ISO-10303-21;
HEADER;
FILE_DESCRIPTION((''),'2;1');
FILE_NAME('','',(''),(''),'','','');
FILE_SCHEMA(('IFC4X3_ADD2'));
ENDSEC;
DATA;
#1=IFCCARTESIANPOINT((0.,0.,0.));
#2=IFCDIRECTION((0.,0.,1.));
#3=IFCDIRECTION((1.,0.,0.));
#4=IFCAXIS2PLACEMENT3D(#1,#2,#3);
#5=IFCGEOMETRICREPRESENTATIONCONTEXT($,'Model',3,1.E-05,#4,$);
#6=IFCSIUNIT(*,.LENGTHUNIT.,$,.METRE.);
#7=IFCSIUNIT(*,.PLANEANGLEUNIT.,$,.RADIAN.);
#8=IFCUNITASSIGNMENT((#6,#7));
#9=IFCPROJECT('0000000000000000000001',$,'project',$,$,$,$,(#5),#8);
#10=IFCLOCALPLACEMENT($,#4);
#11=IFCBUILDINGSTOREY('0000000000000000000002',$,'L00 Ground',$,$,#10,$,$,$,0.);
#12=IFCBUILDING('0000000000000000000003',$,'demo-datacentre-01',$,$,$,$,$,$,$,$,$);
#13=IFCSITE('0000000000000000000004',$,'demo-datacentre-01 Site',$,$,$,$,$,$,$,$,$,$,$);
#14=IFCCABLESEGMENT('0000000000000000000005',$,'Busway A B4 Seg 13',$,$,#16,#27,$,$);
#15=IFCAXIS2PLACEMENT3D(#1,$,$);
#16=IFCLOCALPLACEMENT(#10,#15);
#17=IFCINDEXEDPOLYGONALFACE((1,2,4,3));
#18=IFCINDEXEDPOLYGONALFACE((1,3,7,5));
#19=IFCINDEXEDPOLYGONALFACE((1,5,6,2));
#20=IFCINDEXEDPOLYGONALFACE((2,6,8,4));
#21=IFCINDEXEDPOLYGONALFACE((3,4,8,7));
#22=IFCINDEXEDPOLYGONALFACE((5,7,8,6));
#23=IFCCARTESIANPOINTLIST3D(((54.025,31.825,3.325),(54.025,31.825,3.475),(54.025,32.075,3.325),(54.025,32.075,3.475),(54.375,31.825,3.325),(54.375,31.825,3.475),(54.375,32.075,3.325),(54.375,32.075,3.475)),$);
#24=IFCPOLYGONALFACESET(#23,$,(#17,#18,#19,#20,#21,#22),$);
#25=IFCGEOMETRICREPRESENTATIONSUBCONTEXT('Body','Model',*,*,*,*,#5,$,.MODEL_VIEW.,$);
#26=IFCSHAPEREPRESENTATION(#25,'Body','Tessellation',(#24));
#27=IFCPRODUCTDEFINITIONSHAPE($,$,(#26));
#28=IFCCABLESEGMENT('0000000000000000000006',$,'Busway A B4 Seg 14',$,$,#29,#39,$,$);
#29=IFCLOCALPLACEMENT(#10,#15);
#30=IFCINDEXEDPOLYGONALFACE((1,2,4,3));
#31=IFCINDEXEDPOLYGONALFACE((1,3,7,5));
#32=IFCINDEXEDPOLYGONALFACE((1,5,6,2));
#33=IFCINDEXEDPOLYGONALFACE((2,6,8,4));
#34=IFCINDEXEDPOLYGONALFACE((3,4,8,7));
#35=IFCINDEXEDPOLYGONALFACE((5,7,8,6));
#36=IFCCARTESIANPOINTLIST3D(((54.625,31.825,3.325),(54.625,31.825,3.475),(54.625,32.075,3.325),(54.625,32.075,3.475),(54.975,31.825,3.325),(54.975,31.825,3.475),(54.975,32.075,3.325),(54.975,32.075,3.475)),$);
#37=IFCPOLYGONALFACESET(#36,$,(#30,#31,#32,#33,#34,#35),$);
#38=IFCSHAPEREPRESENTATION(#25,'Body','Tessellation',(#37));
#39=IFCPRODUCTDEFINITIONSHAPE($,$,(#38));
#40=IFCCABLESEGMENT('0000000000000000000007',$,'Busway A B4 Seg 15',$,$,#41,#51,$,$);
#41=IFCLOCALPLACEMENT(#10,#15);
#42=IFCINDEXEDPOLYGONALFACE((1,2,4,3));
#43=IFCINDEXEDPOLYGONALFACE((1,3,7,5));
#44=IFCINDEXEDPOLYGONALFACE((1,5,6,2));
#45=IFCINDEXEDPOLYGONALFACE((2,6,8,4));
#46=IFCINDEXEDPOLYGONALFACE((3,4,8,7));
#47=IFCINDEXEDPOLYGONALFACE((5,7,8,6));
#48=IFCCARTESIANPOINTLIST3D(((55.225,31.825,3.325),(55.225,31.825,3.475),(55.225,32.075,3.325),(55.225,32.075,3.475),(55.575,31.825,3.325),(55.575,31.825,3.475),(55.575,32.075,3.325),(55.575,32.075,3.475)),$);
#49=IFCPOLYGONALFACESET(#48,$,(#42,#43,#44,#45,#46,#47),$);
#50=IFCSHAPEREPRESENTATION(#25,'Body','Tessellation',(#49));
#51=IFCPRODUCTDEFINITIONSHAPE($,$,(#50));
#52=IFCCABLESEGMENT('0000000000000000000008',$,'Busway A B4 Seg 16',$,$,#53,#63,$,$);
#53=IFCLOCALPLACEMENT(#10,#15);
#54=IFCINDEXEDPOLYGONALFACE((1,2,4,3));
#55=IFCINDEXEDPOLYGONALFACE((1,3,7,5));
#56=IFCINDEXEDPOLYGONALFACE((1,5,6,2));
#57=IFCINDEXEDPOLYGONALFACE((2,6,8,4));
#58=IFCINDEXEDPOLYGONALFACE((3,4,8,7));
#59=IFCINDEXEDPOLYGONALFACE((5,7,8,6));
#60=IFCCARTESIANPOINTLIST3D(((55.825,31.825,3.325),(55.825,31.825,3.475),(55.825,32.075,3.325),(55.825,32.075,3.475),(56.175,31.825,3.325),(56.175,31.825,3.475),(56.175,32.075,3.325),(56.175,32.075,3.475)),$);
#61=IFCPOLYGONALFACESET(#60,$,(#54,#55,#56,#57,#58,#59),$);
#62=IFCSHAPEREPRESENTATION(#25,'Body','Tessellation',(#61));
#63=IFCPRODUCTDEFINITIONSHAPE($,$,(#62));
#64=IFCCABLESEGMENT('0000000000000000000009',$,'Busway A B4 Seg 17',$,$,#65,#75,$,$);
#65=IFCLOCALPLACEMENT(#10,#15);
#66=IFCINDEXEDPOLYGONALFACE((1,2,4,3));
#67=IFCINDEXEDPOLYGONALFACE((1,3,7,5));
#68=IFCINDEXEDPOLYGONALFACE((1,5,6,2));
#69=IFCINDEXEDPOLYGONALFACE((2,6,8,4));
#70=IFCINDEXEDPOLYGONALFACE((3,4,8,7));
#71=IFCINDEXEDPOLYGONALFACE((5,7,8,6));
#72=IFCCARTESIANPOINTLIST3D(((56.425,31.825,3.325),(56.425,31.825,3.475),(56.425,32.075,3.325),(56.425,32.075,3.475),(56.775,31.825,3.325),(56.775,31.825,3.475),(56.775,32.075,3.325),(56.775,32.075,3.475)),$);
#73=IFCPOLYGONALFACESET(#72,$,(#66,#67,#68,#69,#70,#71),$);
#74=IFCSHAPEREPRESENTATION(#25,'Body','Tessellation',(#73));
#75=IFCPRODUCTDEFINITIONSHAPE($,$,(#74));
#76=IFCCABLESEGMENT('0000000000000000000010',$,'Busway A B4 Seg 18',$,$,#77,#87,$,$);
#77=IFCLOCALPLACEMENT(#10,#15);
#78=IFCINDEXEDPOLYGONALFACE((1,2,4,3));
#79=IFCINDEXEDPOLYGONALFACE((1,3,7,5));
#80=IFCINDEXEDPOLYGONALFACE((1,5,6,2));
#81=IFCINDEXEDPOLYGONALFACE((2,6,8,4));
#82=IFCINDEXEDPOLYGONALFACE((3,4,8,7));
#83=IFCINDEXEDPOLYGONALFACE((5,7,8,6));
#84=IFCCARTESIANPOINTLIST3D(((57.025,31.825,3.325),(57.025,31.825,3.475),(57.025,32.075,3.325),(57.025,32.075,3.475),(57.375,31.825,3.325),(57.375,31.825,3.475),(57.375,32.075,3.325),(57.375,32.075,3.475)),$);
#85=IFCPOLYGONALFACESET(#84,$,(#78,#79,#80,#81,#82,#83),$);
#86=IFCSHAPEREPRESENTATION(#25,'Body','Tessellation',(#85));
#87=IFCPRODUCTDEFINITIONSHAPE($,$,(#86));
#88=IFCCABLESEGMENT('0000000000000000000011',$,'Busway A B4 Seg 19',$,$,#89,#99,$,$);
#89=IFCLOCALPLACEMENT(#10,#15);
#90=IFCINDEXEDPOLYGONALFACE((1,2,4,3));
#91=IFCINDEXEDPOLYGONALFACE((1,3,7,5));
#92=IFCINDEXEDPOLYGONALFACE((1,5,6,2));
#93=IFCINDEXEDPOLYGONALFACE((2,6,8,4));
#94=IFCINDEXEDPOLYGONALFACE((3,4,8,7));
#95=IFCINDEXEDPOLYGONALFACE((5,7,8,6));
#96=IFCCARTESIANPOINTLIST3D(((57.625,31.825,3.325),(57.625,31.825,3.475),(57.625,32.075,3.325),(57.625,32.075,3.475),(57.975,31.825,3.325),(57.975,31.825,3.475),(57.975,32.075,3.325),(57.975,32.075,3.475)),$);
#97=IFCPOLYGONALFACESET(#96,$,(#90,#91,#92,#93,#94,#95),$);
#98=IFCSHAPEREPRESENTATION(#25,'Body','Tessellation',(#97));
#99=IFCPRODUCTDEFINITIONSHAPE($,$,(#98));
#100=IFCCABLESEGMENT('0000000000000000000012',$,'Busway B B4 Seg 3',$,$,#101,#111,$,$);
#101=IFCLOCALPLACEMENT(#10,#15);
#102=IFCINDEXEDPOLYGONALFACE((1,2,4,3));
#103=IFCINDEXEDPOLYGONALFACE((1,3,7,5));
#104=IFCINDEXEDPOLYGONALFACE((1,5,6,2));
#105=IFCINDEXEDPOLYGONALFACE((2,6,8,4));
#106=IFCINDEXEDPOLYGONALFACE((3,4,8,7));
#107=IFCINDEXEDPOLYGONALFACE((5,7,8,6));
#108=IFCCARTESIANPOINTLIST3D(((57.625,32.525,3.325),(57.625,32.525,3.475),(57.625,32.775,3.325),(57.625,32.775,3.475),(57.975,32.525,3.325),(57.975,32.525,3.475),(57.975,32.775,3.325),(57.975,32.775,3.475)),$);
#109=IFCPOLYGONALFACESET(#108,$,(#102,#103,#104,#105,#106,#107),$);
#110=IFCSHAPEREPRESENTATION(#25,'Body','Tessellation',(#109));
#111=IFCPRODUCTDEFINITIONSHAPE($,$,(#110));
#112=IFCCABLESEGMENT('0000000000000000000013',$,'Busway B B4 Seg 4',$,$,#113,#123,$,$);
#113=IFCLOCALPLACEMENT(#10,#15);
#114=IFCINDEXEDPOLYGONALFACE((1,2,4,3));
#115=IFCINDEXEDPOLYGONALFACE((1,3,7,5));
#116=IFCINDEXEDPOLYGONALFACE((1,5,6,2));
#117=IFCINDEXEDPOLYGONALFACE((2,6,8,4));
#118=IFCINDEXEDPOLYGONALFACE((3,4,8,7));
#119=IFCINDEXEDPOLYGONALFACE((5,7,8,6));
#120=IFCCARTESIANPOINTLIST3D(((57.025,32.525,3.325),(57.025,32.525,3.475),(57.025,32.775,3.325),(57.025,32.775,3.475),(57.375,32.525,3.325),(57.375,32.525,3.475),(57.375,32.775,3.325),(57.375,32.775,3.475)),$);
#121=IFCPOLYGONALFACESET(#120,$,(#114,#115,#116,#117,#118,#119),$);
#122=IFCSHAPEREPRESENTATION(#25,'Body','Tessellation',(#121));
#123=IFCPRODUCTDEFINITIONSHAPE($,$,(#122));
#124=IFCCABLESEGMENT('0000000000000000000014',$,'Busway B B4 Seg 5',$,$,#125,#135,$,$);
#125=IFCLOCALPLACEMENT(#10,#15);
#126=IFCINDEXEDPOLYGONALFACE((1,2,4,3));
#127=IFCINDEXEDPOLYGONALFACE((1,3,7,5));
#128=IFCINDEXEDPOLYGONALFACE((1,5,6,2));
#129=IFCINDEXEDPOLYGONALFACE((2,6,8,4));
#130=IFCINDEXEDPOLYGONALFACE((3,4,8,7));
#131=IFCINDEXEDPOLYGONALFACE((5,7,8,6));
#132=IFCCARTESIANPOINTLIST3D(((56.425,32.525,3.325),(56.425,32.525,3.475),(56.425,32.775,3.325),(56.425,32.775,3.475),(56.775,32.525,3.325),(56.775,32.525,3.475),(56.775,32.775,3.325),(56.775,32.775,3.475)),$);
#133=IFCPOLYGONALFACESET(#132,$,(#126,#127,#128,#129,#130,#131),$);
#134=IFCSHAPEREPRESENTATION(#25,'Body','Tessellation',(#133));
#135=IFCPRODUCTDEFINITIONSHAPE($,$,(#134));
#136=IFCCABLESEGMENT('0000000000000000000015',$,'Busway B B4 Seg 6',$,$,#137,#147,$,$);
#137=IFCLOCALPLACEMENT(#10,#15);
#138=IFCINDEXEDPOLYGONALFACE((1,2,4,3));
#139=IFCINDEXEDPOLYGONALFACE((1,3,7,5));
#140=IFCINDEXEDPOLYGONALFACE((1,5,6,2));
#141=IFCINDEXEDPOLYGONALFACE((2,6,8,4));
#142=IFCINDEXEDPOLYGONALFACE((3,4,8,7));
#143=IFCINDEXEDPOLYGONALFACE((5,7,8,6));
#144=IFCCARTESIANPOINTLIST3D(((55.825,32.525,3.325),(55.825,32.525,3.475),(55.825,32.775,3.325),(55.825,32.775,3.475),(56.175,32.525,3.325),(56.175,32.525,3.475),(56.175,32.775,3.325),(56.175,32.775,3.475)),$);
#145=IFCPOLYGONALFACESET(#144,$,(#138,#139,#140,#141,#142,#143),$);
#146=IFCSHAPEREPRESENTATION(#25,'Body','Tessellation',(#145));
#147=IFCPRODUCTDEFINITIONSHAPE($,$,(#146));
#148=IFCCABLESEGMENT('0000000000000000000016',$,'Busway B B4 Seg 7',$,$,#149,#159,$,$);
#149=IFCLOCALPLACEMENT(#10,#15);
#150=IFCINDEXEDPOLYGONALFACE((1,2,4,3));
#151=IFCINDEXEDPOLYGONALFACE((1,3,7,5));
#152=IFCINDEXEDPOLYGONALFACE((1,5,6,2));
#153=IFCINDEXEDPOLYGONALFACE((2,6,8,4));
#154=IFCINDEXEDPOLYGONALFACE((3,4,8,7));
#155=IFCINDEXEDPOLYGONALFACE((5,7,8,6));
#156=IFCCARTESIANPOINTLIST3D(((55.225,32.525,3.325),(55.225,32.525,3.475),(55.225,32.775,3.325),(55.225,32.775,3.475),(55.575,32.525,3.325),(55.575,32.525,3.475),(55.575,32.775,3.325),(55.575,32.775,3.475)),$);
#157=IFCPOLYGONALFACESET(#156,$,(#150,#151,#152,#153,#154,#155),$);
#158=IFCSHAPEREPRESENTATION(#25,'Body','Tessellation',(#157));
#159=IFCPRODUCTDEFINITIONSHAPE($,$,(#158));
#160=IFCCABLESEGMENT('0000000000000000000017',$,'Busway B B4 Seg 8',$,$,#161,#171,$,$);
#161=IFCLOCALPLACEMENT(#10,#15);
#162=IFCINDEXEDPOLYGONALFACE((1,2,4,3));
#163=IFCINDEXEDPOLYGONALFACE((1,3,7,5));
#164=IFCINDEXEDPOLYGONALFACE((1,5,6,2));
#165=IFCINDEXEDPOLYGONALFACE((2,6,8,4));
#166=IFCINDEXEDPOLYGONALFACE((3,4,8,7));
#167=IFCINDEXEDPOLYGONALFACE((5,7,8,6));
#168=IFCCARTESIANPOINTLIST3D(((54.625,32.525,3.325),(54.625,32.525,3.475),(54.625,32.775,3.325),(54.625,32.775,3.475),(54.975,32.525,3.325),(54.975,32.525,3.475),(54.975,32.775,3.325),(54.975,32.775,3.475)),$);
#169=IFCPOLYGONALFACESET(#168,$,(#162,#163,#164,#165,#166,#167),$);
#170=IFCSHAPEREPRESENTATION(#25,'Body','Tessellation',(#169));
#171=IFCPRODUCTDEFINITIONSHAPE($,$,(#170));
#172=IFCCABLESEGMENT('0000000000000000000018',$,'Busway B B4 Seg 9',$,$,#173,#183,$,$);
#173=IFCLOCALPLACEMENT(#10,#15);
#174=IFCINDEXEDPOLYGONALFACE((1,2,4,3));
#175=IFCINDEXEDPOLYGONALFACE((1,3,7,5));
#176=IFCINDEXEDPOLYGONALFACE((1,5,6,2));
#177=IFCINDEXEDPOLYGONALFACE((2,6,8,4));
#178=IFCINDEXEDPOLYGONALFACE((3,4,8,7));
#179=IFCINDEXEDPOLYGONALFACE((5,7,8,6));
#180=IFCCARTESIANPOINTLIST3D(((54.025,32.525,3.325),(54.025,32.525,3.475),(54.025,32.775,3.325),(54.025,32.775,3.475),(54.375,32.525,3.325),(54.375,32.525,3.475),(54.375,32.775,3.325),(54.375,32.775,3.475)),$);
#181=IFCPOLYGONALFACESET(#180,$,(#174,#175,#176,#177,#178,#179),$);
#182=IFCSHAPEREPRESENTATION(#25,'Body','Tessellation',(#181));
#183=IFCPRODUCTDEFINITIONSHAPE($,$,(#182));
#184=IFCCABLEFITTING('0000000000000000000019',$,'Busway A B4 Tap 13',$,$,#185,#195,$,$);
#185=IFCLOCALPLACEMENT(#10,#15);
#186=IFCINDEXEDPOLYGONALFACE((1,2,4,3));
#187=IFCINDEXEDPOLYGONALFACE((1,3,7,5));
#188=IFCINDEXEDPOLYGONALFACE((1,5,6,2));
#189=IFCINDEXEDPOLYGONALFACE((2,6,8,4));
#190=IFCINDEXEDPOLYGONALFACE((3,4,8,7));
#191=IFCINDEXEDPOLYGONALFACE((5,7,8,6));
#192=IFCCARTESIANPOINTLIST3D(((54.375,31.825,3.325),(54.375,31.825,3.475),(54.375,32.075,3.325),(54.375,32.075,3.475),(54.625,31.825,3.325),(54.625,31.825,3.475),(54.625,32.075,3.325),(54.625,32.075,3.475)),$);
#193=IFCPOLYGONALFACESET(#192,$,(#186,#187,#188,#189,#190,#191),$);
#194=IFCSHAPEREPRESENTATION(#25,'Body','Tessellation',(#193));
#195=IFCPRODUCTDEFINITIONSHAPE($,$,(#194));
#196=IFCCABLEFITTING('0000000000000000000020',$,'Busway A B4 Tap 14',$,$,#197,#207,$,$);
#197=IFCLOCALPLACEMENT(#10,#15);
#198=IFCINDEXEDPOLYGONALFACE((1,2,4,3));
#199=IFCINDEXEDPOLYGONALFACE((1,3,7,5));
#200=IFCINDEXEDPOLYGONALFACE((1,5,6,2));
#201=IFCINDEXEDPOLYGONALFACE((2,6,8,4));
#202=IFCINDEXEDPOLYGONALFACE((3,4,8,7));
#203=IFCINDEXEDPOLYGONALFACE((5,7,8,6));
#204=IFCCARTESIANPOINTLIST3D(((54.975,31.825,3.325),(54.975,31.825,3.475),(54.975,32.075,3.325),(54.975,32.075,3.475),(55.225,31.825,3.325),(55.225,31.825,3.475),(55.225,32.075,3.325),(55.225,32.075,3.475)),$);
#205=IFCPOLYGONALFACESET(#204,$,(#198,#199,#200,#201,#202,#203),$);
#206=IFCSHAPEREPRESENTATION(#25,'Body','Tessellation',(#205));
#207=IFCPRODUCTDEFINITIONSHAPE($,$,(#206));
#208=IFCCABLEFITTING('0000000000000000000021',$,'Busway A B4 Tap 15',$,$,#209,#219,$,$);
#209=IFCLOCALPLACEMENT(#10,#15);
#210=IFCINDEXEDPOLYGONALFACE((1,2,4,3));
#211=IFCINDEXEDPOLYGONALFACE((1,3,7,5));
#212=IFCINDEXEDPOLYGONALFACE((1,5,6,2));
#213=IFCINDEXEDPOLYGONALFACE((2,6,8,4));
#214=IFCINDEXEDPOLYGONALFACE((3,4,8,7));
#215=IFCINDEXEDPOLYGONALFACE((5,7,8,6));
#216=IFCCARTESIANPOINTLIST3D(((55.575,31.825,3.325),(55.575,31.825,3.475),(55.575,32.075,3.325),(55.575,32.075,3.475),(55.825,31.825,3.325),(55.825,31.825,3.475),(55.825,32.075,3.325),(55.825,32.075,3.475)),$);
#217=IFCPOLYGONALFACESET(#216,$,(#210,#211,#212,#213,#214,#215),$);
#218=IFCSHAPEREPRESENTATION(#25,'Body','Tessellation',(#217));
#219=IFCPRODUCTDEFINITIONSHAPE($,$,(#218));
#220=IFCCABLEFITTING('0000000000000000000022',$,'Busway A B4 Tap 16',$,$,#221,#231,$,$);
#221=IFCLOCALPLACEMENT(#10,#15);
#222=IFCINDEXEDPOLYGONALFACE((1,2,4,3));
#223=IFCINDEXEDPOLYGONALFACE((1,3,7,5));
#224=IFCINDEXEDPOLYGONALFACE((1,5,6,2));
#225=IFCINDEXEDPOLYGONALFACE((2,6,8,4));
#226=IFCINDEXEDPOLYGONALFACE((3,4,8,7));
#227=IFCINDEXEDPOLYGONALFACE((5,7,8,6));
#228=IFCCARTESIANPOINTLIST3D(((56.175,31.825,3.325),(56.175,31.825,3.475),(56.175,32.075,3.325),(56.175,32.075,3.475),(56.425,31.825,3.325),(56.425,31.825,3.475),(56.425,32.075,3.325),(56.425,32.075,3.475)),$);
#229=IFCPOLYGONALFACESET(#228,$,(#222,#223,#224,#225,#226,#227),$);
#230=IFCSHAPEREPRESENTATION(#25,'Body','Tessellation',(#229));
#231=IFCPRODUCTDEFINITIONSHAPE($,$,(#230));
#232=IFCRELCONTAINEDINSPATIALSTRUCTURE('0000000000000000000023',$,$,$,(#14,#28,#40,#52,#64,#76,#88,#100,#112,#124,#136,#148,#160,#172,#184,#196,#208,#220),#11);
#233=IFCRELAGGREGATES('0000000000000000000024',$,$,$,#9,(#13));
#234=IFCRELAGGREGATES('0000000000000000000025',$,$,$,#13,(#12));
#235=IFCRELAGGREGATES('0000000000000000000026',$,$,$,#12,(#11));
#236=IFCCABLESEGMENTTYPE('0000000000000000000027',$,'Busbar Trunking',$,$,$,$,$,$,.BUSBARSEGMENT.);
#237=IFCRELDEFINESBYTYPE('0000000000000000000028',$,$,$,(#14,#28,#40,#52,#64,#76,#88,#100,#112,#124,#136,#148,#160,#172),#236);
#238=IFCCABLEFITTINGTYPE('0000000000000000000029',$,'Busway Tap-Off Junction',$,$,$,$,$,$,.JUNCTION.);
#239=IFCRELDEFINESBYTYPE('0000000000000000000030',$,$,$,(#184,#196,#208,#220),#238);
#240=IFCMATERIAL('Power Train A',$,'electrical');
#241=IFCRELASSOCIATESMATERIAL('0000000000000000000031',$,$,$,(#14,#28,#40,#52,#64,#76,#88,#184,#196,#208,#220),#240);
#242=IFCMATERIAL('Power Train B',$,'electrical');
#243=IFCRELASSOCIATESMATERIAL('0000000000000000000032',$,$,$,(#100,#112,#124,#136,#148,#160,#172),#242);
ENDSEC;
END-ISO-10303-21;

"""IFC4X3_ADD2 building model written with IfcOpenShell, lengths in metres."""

from ifc_helpers import new_model, si_unit, frame, origin_with_axes, place, context, subcontext, project, spatial, rectangle, extrude, material, type_object, element, save


model = new_model("IFC4X3_ADD2")

# Units and contexts
model_context = context("Model", 3, precision=1e-05, world=origin_with_axes())
body_context = subcontext(model_context, "Body", "Model", "MODEL_VIEW")
ifc_project = project(units=[si_unit("LENGTHUNIT", "METRE"), si_unit("PLANEANGLEUNIT", "RADIAN")], contexts=[model_context])

# Site, building, storey
site = spatial("IfcSite", under=ifc_project, Name="demo-datacentre-01 Site")
building = spatial("IfcBuilding", under=site, Name="demo-datacentre-01")
storey_placement = place(None, origin_with_axes())
storey = spatial("IfcBuildingStorey", under=building, at=storey_placement, Name="L00 Ground", Elevation=0.0)

# Cable segments
ifc_material_1 = material(Name="Power Train A", Category="electrical")
cable_segment_type_1 = type_object("IfcCableSegmentType", Name="Busbar Trunking", PredefinedType="BUSBARSEGMENT")
cable_segment_1_placement = place(storey_placement, frame((54.025, 31.95, 3.4), z_axis=(1.0, 0.0, 0.0), x_axis=(0.0, 1.0, 0.0)))
element("IfcCableSegment", 1, at=cable_segment_1_placement, inside=storey, type_object=cable_segment_type_1, material=ifc_material_1, Name="Busway A B4 Seg 13", context=body_context, shape_type="SweptSolid", body=[
    extrude(rectangle(XDim=0.25, YDim=0.15), origin_with_axes(), (0.0, 0.0, 1.0), 0.35),
])
cable_segment_2_placement = place(storey_placement, frame((54.625, 31.95, 3.4), z_axis=(1.0, 0.0, 0.0), x_axis=(0.0, 1.0, 0.0)))
element("IfcCableSegment", 2, at=cable_segment_2_placement, inside=storey, type_object=cable_segment_type_1, material=ifc_material_1, Name="Busway A B4 Seg 14", context=body_context, shape_type="SweptSolid", body=[
    extrude(rectangle(XDim=0.25, YDim=0.15), origin_with_axes(), (0.0, 0.0, 1.0), 0.35),
])
for number, where, z_axis, x_axis, name in (
    (3, (55.225, 31.95, 3.4), (1.0, 0.0, 0.0), (0.0, 1.0, 0.0), "Busway A B4 Seg 15"),
    (4, (55.825, 31.95, 3.4), (1.0, 0.0, 0.0), (0.0, 1.0, 0.0), "Busway A B4 Seg 16"),
    (5, (56.425, 31.95, 3.4), (1.0, 0.0, 0.0), (0.0, 1.0, 0.0), "Busway A B4 Seg 17"),
    (6, (57.025, 31.95, 3.4), (1.0, 0.0, 0.0), (0.0, 1.0, 0.0), "Busway A B4 Seg 18"),
):
    element("IfcCableSegment", number, at=place(storey_placement, frame(where, z_axis=z_axis, x_axis=x_axis)), inside=storey, type_object=cable_segment_type_1, material=ifc_material_1, Name=name, context=body_context, shape_type="SweptSolid", body=[
        extrude(rectangle(XDim=0.25, YDim=0.15), origin_with_axes(), (0.0, 0.0, 1.0), 0.35),
    ])
cable_segment_3_placement = place(storey_placement, frame((57.625, 31.95, 3.4), z_axis=(1.0, 0.0, 0.0), x_axis=(0.0, 1.0, 0.0)))
element("IfcCableSegment", 7, at=cable_segment_3_placement, inside=storey, type_object=cable_segment_type_1, material=ifc_material_1, Name="Busway A B4 Seg 19", context=body_context, shape_type="SweptSolid", body=[
    extrude(rectangle(XDim=0.25, YDim=0.15), origin_with_axes(), (0.0, 0.0, 1.0), 0.35),
])
ifc_material_2 = material(Name="Power Train B", Category="electrical")
cable_segment_4_placement = place(storey_placement, frame((57.975, 32.65, 3.4), z_axis=(-1.0, 0.0, 0.0), x_axis=(0.0, -1.0, 0.0)))
element("IfcCableSegment", 8, at=cable_segment_4_placement, inside=storey, type_object=cable_segment_type_1, material=ifc_material_2, Name="Busway B B4 Seg 3", context=body_context, shape_type="SweptSolid", body=[
    extrude(rectangle(XDim=0.25, YDim=0.15), origin_with_axes(), (0.0, 0.0, 1.0), 0.35),
])
for number, where, z_axis, x_axis, name in (
    (9, (57.375, 32.65, 3.4), (-1.0, 0.0, 0.0), (0.0, -1.0, 0.0), "Busway B B4 Seg 4"),
    (10, (56.775, 32.65, 3.4), (-1.0, 0.0, 0.0), (0.0, -1.0, 0.0), "Busway B B4 Seg 5"),
    (11, (56.175, 32.65, 3.4), (-1.0, 0.0, 0.0), (0.0, -1.0, 0.0), "Busway B B4 Seg 6"),
    (12, (55.575, 32.65, 3.4), (-1.0, 0.0, 0.0), (0.0, -1.0, 0.0), "Busway B B4 Seg 7"),
):
    element("IfcCableSegment", number, at=place(storey_placement, frame(where, z_axis=z_axis, x_axis=x_axis)), inside=storey, type_object=cable_segment_type_1, material=ifc_material_2, Name=name, context=body_context, shape_type="SweptSolid", body=[
        extrude(rectangle(XDim=0.25, YDim=0.15), origin_with_axes(), (0.0, 0.0, 1.0), 0.35),
    ])
cable_segment_5_placement = place(storey_placement, frame((54.975, 32.65, 3.4), z_axis=(-1.0, 0.0, 0.0), x_axis=(0.0, -1.0, 0.0)))
element("IfcCableSegment", 13, at=cable_segment_5_placement, inside=storey, type_object=cable_segment_type_1, material=ifc_material_2, Name="Busway B B4 Seg 8", context=body_context, shape_type="SweptSolid", body=[
    extrude(rectangle(XDim=0.25, YDim=0.15), origin_with_axes(), (0.0, 0.0, 1.0), 0.35),
])
cable_segment_6_placement = place(storey_placement, frame((54.375, 32.65, 3.4), z_axis=(-1.0, 0.0, 0.0), x_axis=(0.0, -1.0, 0.0)))
element("IfcCableSegment", 14, at=cable_segment_6_placement, inside=storey, type_object=cable_segment_type_1, material=ifc_material_2, Name="Busway B B4 Seg 9", context=body_context, shape_type="SweptSolid", body=[
    extrude(rectangle(XDim=0.25, YDim=0.15), origin_with_axes(), (0.0, 0.0, 1.0), 0.35),
])

# Cable fittings
cable_fitting_type = type_object("IfcCableFittingType", Name="Busway Tap-Off Junction", PredefinedType="JUNCTION")
for number, where, z_axis, x_axis, name in (
    (15, (54.5, 31.95, 3.325), (0.0, 0.0, 1.0), (1.0, 0.0, 0.0), "Busway A B4 Tap 13"),
    (16, (55.1, 31.95, 3.325), (0.0, 0.0, 1.0), (1.0, 0.0, 0.0), "Busway A B4 Tap 14"),
    (17, (55.7, 31.95, 3.325), (0.0, 0.0, 1.0), (1.0, 0.0, 0.0), "Busway A B4 Tap 15"),
    (18, (56.3, 31.95, 3.325), (0.0, 0.0, 1.0), (1.0, 0.0, 0.0), "Busway A B4 Tap 16"),
):
    element("IfcCableFitting", number, at=place(storey_placement, frame(where, z_axis=z_axis, x_axis=x_axis)), inside=storey, type_object=cable_fitting_type, material=ifc_material_1, Name=name, context=body_context, shape_type="SweptSolid", body=[
        extrude(rectangle(XDim=0.25, YDim=0.25), origin_with_axes(), (0.0, 0.0, 1.0), 0.15),
    ])

save(model, "model.ifc")
